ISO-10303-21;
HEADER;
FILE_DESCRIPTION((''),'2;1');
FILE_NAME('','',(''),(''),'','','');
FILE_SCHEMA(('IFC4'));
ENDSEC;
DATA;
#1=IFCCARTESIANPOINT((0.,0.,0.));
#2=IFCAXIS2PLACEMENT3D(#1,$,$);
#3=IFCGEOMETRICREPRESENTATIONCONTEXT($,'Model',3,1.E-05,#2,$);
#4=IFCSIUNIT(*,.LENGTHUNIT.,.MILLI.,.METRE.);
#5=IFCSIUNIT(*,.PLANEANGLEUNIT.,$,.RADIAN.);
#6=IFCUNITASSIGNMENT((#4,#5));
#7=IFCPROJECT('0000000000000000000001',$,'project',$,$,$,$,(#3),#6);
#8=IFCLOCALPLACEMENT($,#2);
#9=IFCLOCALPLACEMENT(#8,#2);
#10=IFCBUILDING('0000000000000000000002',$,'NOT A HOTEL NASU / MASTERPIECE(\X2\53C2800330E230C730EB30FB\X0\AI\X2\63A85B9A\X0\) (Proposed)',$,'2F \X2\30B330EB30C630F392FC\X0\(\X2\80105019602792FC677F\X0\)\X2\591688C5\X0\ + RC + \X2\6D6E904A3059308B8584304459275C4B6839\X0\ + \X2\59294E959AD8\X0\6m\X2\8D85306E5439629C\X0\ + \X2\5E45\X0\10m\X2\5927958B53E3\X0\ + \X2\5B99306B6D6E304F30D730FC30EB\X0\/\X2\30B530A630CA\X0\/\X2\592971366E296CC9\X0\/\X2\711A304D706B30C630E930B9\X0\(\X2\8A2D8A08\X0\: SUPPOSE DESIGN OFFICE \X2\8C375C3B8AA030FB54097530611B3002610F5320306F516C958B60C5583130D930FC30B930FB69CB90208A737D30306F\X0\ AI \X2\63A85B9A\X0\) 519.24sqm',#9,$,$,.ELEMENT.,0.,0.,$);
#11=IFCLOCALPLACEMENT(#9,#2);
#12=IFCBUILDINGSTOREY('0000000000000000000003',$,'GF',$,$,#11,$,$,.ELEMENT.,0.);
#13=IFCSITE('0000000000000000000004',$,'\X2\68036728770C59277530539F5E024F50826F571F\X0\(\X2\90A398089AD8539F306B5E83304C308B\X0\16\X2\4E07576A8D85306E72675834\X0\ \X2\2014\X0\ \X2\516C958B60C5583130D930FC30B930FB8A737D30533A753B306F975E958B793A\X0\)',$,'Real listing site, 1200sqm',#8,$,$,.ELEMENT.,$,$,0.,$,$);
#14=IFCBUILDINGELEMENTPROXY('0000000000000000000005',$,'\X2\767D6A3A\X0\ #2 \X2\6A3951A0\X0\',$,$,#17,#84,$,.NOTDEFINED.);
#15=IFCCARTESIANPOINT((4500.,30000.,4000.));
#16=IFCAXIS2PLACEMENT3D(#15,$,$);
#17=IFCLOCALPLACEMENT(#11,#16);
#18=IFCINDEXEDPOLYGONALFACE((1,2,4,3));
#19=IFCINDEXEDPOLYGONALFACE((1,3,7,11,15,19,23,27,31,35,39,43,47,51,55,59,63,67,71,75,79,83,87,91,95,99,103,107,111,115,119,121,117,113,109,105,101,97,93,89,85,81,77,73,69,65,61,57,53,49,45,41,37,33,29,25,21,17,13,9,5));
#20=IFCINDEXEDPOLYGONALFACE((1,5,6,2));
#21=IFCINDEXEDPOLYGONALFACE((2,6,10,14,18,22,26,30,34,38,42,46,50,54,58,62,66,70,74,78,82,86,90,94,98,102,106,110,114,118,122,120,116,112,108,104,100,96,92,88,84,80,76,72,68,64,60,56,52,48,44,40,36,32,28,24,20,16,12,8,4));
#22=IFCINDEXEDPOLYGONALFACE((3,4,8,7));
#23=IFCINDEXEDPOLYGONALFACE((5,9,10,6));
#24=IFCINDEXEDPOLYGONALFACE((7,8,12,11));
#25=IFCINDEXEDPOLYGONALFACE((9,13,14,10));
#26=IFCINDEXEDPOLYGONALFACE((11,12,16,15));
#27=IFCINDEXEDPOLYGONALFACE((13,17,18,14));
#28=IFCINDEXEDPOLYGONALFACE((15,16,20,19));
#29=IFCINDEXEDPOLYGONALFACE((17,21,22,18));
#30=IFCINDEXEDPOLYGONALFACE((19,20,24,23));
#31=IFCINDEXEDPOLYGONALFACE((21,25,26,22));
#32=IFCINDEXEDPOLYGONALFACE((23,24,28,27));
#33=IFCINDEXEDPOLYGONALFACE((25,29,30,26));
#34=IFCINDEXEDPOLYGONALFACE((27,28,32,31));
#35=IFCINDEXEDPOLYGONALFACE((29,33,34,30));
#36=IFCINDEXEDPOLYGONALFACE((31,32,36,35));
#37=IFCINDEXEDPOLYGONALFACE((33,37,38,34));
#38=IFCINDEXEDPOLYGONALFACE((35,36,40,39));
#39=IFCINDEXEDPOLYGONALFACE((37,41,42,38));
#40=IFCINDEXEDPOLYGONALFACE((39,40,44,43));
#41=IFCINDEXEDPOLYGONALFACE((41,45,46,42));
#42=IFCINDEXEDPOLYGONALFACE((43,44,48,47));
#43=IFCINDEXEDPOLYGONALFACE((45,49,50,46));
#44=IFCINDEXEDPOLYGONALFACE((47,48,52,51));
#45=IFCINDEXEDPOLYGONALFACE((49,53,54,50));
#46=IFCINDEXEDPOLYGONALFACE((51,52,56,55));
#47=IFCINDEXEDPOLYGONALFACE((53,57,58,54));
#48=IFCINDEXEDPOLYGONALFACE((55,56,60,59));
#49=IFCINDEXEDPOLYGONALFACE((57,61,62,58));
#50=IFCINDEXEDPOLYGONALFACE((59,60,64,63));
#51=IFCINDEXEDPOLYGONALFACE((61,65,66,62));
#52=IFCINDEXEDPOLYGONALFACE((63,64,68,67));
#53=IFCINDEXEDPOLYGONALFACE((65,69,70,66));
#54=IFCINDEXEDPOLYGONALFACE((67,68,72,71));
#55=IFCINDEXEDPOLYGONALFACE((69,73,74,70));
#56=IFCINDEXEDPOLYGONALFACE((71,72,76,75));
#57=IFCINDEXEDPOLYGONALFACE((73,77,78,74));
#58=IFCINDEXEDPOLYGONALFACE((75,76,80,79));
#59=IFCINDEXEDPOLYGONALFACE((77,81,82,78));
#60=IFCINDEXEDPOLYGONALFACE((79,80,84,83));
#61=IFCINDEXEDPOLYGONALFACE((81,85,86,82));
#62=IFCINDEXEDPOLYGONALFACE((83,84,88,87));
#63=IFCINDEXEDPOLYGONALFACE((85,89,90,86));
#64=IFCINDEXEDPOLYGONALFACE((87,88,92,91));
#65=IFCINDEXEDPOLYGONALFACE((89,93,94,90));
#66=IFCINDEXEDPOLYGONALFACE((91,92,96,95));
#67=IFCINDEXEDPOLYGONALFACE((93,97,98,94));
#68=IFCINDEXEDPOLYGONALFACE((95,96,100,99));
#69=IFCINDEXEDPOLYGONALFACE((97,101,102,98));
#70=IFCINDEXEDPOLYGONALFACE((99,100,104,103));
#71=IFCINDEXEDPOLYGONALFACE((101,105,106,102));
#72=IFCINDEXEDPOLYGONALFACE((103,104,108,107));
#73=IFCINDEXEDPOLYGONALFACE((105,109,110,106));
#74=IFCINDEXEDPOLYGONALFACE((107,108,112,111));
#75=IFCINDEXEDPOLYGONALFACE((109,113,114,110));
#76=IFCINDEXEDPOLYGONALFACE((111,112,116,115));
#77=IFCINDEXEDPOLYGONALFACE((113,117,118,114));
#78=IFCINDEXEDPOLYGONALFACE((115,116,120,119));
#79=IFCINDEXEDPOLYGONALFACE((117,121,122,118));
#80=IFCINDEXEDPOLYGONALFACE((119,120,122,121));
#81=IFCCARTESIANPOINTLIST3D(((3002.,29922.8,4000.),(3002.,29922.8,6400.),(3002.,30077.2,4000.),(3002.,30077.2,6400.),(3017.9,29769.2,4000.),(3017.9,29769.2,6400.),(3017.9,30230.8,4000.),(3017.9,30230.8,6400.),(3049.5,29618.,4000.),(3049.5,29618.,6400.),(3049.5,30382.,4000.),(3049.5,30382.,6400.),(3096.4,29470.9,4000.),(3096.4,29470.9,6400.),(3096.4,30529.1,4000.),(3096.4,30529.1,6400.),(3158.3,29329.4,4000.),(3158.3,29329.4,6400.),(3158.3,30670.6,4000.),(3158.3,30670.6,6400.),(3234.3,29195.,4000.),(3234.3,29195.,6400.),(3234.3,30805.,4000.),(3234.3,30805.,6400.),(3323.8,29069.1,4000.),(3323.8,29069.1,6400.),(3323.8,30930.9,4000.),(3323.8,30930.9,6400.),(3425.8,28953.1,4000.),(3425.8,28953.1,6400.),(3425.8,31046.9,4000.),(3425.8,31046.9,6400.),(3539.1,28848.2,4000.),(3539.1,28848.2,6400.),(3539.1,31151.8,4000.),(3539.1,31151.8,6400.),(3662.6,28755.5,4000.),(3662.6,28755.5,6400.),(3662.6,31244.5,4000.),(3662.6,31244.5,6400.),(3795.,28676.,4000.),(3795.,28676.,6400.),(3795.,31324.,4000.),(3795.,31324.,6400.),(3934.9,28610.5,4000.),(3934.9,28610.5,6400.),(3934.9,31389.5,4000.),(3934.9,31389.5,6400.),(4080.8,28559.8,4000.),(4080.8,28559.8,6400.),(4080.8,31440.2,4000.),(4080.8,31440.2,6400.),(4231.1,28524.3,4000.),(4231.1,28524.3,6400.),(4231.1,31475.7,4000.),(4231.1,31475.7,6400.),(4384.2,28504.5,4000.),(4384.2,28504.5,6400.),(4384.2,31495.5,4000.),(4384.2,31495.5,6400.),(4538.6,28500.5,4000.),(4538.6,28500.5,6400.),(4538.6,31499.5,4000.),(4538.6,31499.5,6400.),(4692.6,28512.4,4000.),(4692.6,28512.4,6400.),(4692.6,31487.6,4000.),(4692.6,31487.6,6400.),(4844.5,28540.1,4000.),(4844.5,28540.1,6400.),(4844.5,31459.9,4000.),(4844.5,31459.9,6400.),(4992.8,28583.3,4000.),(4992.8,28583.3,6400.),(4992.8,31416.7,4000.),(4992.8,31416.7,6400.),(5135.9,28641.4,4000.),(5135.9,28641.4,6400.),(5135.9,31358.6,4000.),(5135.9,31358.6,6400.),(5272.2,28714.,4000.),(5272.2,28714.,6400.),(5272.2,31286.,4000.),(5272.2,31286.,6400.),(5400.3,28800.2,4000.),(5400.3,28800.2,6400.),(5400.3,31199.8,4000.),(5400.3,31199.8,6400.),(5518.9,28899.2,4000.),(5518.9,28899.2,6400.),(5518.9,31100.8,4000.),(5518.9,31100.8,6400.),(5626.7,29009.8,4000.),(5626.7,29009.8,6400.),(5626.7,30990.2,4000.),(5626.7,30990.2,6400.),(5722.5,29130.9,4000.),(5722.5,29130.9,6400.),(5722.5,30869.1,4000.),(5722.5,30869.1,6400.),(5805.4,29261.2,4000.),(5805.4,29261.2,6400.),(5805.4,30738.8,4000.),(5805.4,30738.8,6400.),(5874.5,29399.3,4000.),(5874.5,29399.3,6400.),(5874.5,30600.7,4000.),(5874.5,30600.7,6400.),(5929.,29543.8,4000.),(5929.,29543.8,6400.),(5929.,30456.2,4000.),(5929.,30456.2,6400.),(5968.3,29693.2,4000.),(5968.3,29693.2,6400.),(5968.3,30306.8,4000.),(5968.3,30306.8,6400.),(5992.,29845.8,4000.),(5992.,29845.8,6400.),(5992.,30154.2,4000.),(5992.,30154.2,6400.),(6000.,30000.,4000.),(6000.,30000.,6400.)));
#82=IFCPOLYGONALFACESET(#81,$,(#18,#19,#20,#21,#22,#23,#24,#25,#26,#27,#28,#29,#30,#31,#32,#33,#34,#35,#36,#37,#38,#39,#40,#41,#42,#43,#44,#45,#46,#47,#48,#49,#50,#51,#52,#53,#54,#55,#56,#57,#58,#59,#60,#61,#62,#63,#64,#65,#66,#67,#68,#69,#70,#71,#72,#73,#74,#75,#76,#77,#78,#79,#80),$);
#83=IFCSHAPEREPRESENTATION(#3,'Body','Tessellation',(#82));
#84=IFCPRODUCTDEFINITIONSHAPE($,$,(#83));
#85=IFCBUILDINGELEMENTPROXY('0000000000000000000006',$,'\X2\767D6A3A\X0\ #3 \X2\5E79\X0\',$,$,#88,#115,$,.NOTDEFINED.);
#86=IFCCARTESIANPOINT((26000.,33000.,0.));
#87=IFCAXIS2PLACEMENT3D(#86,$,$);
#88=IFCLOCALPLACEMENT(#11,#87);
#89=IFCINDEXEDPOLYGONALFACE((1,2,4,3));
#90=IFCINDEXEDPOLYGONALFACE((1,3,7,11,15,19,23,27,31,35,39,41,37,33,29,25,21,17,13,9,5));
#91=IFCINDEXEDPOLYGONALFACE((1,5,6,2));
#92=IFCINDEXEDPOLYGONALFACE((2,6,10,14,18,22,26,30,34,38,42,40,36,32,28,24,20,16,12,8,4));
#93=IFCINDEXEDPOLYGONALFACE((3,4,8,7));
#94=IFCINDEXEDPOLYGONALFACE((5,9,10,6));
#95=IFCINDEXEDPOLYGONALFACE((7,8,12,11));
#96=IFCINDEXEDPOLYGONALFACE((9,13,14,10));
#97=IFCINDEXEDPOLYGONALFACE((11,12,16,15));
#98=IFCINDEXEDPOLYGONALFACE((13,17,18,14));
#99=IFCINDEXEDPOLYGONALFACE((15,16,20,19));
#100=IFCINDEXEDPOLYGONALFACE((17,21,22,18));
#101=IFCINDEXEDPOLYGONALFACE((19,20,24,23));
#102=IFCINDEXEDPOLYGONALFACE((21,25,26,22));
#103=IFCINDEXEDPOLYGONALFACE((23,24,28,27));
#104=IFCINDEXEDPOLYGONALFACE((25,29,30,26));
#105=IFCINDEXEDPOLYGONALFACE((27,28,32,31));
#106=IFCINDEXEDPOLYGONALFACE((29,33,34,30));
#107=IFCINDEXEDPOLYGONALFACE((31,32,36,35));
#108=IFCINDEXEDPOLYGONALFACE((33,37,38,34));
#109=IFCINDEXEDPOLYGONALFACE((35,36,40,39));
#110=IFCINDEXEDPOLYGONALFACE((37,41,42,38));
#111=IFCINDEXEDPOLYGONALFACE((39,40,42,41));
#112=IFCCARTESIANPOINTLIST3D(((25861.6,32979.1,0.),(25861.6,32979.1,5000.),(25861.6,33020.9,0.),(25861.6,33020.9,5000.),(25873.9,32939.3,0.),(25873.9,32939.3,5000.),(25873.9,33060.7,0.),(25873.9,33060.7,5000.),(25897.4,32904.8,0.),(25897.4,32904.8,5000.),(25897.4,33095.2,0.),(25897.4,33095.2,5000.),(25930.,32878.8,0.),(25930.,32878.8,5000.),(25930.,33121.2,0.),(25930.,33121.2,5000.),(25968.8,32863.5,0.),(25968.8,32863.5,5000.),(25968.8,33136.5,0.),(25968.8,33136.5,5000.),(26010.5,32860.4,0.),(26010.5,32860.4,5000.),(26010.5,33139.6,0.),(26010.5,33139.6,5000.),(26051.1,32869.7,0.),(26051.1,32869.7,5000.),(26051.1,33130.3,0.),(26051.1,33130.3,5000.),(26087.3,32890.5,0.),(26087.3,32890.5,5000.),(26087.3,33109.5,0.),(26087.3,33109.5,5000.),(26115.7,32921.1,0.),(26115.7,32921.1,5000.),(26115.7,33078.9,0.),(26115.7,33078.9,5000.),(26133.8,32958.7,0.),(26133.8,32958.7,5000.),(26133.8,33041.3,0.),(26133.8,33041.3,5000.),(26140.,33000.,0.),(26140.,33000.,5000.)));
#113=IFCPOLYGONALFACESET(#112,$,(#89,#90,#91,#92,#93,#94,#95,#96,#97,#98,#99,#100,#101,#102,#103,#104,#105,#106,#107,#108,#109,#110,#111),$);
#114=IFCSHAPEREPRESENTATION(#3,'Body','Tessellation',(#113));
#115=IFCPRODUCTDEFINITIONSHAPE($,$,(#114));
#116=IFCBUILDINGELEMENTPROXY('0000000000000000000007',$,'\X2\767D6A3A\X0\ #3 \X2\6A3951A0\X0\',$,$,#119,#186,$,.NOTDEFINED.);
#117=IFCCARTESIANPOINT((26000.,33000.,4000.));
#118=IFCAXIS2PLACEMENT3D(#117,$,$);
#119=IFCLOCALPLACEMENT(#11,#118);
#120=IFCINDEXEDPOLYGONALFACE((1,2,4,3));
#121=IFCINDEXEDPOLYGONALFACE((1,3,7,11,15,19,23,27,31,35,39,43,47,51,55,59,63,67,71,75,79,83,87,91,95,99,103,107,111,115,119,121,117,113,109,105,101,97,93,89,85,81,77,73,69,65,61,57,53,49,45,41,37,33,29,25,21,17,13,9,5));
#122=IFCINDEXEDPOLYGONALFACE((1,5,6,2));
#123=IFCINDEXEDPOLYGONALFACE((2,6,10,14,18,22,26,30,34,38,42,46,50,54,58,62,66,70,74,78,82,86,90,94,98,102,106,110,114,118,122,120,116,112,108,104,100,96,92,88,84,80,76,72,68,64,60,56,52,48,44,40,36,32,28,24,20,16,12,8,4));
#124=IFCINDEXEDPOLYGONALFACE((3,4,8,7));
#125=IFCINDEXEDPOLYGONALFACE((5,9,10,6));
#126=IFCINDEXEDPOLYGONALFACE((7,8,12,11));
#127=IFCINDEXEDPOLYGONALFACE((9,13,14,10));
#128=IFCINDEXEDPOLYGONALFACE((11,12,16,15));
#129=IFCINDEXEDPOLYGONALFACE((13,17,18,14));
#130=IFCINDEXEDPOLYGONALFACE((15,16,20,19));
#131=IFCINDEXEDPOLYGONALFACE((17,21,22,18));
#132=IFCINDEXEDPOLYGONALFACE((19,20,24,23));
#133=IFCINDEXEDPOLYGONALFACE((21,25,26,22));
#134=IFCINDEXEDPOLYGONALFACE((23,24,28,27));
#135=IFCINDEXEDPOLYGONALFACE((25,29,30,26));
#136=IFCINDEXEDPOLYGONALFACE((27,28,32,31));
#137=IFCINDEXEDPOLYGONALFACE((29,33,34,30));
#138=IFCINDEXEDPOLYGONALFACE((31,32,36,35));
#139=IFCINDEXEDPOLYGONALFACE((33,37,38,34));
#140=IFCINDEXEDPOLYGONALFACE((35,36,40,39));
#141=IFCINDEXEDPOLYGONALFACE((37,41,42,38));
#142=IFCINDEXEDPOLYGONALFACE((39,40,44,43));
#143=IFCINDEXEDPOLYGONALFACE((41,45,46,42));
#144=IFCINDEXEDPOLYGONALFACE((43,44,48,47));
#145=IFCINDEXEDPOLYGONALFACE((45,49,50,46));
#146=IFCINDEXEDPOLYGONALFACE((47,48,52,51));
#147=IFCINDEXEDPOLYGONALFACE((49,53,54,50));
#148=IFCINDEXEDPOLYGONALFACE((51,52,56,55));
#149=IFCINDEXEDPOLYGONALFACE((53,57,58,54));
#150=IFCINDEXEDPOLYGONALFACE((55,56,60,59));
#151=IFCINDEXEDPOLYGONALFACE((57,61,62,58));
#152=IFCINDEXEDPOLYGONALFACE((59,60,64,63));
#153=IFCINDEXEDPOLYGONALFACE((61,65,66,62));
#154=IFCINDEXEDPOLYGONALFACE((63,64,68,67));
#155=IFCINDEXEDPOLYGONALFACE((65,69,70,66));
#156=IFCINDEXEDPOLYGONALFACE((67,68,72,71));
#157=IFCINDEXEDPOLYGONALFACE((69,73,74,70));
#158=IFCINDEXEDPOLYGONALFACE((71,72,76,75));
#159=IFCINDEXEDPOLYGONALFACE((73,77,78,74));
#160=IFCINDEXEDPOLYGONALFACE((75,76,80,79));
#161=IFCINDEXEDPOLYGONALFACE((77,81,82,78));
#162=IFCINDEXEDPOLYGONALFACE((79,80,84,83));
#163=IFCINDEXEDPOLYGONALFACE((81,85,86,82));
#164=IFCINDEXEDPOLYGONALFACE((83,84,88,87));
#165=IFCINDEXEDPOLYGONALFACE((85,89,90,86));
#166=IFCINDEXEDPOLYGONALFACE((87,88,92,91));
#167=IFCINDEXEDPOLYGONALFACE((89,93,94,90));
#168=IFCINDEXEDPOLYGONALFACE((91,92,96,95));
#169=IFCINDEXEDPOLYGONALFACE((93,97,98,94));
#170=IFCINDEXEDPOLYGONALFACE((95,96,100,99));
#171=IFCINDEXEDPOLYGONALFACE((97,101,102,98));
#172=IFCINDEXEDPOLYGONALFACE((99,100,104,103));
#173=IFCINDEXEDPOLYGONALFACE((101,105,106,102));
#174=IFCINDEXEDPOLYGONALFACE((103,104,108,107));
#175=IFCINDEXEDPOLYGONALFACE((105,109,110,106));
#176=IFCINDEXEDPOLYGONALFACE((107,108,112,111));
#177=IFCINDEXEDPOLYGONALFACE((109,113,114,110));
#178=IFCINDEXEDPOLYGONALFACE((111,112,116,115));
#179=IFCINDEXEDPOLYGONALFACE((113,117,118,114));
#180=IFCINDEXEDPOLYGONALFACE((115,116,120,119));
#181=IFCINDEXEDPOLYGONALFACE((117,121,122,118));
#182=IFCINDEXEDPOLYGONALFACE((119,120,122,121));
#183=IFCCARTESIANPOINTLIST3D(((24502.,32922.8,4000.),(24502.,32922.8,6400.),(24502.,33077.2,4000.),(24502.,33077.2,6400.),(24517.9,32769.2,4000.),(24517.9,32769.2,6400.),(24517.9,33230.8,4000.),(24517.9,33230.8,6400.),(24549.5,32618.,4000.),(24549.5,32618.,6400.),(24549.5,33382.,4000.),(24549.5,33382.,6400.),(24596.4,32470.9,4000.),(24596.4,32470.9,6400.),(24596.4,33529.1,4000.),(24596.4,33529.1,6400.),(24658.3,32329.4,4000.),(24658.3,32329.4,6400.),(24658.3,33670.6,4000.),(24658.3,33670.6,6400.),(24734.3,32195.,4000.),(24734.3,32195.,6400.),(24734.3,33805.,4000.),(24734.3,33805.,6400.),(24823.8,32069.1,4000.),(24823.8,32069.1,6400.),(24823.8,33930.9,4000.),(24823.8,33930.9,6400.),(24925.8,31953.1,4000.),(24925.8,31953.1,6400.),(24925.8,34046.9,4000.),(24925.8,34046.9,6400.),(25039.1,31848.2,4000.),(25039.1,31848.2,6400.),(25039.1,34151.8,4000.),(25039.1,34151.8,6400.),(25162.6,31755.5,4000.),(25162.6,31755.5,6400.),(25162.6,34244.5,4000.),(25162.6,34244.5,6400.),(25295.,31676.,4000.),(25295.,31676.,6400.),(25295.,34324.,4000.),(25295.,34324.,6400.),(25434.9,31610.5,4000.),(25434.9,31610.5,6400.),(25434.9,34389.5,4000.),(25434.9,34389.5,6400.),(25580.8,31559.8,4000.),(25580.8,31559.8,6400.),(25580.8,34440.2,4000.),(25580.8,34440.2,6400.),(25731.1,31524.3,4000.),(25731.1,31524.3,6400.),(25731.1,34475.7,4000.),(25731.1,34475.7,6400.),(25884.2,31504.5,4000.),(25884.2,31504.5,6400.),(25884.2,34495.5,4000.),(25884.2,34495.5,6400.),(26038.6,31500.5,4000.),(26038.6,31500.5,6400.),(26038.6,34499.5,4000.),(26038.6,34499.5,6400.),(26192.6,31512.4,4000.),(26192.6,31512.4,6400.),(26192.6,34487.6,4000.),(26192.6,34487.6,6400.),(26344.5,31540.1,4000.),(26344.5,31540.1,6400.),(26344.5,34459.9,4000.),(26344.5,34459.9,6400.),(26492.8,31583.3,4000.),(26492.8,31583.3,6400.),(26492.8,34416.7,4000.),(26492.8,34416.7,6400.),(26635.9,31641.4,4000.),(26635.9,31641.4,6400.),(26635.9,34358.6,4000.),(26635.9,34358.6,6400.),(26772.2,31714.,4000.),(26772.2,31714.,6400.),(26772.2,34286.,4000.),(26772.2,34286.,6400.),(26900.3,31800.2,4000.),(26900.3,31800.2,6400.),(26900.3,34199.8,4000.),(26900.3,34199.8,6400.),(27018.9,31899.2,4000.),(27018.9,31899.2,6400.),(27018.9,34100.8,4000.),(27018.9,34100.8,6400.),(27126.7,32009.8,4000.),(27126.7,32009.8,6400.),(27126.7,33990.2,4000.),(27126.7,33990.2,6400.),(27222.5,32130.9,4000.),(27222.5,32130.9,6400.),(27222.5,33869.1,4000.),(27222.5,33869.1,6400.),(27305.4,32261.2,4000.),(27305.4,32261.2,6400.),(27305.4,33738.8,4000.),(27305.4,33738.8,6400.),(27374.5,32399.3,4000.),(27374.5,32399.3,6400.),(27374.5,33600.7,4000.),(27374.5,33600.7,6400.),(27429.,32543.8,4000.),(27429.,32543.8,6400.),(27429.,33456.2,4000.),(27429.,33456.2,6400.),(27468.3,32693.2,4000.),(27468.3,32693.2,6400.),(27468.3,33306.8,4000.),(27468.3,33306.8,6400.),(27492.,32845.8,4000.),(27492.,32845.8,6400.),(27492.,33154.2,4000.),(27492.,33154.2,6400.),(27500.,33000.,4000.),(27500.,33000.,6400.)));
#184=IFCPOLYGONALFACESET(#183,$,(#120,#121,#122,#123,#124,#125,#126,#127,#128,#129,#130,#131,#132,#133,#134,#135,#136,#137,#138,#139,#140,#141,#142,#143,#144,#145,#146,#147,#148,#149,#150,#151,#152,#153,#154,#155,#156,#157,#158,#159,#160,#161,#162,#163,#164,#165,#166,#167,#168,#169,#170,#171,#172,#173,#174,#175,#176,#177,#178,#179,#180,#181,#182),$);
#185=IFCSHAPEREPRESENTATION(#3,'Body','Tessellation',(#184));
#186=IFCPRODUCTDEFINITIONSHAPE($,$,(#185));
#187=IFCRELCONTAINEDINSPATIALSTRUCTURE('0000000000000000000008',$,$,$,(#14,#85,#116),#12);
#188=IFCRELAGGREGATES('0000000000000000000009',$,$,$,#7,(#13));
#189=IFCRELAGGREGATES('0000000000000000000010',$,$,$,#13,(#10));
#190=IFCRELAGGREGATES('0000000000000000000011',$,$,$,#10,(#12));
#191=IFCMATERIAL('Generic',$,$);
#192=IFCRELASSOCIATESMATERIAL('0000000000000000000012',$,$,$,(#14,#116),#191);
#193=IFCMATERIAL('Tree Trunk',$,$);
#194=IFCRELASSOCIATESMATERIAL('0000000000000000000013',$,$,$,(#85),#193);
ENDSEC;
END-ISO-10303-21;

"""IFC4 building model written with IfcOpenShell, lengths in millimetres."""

from ifc_helpers import new_model, si_unit, frame, origin, origin_2d, place, context, project, spatial, circle, extrude, material, element, save


model = new_model("IFC4")

# Units and contexts
model_context = context("Model", 3, precision=1e-05, world=origin())
ifc_project = project(units=[si_unit("LENGTHUNIT", "METRE", prefix="MILLI"), si_unit("PLANEANGLEUNIT", "RADIAN")], contexts=[model_context])

# Site, building, storey
site_placement = place(None, origin())
site = spatial("IfcSite", under=ifc_project, at=site_placement, Name="栃木県大田原市佐良土(那須高原に広がる16万坪超の牧場 — 公開情報ベース・詳細区画は非開示)", ObjectType="Real listing site, 1200sqm", CompositionType="ELEMENT", RefElevation=0.0)
building_placement = place(site_placement, origin())
building = spatial("IfcBuilding", under=site, at=building_placement, Name="NOT A HOTEL NASU / MASTERPIECE(参考モデル・AI推定) (Proposed)", ObjectType="2F コルテン鋼(耐候性鋼板)外装 + RC + 浮遊する薄い大屋根 + 天井高6m超の吹抜 + 幅10m大開口 + 宙に浮くプール/サウナ/天然温泉/焚き火テラス(設計: SUPPOSE DESIGN OFFICE 谷尻誠・吉田愛。意匠は公開情報ベース・構造詳細は AI 推定) 519.24sqm", CompositionType="ELEMENT", ElevationOfRefHeight=0.0, ElevationOfTerrain=0.0)
storey_placement = place(building_placement, origin())
storey = spatial("IfcBuildingStorey", under=building, at=storey_placement, Name="GF", CompositionType="ELEMENT", Elevation=0.0)

# Shared definitions
ifc_material_1 = material(Name="Generic")

# Building element proxies
ifc_material_2 = material(Name="Tree Trunk")
proxy_1_placement = place(storey_placement, frame((4500.0, 30000.0, 4000.0)))
element("IfcBuildingElementProxy", 1, at=proxy_1_placement, inside=storey, material=ifc_material_1, Name="白樺 #2 樹冠", PredefinedType="NOTDEFINED", context=model_context, shape_type="SweptSolid", body=[
    extrude(circle(Radius=1500.0, at=origin_2d()), frame((4500.0, 30000.0, 4000.0)), (0.0, 0.0, 1.0), 2400.0),
])
proxy_2_placement = place(storey_placement, frame((26000.0, 33000.0, 0.0)))
element("IfcBuildingElementProxy", 2, at=proxy_2_placement, inside=storey, material=ifc_material_2, Name="白樺 #3 幹", PredefinedType="NOTDEFINED", context=model_context, shape_type="SweptSolid", body=[
    extrude(circle(Radius=140.0, at=origin_2d()), frame((26000.0, 33000.0, 0.0)), (0.0, 0.0, 1.0), 5000.0),
])
proxy_3_placement = place(storey_placement, frame((26000.0, 33000.0, 4000.0)))
element("IfcBuildingElementProxy", 3, at=proxy_3_placement, inside=storey, material=ifc_material_1, Name="白樺 #3 樹冠", PredefinedType="NOTDEFINED", context=model_context, shape_type="SweptSolid", body=[
    extrude(circle(Radius=1500.0, at=origin_2d()), frame((26000.0, 33000.0, 4000.0)), (0.0, 0.0, 1.0), 2400.0),
])

save(model, "model.ifc")
